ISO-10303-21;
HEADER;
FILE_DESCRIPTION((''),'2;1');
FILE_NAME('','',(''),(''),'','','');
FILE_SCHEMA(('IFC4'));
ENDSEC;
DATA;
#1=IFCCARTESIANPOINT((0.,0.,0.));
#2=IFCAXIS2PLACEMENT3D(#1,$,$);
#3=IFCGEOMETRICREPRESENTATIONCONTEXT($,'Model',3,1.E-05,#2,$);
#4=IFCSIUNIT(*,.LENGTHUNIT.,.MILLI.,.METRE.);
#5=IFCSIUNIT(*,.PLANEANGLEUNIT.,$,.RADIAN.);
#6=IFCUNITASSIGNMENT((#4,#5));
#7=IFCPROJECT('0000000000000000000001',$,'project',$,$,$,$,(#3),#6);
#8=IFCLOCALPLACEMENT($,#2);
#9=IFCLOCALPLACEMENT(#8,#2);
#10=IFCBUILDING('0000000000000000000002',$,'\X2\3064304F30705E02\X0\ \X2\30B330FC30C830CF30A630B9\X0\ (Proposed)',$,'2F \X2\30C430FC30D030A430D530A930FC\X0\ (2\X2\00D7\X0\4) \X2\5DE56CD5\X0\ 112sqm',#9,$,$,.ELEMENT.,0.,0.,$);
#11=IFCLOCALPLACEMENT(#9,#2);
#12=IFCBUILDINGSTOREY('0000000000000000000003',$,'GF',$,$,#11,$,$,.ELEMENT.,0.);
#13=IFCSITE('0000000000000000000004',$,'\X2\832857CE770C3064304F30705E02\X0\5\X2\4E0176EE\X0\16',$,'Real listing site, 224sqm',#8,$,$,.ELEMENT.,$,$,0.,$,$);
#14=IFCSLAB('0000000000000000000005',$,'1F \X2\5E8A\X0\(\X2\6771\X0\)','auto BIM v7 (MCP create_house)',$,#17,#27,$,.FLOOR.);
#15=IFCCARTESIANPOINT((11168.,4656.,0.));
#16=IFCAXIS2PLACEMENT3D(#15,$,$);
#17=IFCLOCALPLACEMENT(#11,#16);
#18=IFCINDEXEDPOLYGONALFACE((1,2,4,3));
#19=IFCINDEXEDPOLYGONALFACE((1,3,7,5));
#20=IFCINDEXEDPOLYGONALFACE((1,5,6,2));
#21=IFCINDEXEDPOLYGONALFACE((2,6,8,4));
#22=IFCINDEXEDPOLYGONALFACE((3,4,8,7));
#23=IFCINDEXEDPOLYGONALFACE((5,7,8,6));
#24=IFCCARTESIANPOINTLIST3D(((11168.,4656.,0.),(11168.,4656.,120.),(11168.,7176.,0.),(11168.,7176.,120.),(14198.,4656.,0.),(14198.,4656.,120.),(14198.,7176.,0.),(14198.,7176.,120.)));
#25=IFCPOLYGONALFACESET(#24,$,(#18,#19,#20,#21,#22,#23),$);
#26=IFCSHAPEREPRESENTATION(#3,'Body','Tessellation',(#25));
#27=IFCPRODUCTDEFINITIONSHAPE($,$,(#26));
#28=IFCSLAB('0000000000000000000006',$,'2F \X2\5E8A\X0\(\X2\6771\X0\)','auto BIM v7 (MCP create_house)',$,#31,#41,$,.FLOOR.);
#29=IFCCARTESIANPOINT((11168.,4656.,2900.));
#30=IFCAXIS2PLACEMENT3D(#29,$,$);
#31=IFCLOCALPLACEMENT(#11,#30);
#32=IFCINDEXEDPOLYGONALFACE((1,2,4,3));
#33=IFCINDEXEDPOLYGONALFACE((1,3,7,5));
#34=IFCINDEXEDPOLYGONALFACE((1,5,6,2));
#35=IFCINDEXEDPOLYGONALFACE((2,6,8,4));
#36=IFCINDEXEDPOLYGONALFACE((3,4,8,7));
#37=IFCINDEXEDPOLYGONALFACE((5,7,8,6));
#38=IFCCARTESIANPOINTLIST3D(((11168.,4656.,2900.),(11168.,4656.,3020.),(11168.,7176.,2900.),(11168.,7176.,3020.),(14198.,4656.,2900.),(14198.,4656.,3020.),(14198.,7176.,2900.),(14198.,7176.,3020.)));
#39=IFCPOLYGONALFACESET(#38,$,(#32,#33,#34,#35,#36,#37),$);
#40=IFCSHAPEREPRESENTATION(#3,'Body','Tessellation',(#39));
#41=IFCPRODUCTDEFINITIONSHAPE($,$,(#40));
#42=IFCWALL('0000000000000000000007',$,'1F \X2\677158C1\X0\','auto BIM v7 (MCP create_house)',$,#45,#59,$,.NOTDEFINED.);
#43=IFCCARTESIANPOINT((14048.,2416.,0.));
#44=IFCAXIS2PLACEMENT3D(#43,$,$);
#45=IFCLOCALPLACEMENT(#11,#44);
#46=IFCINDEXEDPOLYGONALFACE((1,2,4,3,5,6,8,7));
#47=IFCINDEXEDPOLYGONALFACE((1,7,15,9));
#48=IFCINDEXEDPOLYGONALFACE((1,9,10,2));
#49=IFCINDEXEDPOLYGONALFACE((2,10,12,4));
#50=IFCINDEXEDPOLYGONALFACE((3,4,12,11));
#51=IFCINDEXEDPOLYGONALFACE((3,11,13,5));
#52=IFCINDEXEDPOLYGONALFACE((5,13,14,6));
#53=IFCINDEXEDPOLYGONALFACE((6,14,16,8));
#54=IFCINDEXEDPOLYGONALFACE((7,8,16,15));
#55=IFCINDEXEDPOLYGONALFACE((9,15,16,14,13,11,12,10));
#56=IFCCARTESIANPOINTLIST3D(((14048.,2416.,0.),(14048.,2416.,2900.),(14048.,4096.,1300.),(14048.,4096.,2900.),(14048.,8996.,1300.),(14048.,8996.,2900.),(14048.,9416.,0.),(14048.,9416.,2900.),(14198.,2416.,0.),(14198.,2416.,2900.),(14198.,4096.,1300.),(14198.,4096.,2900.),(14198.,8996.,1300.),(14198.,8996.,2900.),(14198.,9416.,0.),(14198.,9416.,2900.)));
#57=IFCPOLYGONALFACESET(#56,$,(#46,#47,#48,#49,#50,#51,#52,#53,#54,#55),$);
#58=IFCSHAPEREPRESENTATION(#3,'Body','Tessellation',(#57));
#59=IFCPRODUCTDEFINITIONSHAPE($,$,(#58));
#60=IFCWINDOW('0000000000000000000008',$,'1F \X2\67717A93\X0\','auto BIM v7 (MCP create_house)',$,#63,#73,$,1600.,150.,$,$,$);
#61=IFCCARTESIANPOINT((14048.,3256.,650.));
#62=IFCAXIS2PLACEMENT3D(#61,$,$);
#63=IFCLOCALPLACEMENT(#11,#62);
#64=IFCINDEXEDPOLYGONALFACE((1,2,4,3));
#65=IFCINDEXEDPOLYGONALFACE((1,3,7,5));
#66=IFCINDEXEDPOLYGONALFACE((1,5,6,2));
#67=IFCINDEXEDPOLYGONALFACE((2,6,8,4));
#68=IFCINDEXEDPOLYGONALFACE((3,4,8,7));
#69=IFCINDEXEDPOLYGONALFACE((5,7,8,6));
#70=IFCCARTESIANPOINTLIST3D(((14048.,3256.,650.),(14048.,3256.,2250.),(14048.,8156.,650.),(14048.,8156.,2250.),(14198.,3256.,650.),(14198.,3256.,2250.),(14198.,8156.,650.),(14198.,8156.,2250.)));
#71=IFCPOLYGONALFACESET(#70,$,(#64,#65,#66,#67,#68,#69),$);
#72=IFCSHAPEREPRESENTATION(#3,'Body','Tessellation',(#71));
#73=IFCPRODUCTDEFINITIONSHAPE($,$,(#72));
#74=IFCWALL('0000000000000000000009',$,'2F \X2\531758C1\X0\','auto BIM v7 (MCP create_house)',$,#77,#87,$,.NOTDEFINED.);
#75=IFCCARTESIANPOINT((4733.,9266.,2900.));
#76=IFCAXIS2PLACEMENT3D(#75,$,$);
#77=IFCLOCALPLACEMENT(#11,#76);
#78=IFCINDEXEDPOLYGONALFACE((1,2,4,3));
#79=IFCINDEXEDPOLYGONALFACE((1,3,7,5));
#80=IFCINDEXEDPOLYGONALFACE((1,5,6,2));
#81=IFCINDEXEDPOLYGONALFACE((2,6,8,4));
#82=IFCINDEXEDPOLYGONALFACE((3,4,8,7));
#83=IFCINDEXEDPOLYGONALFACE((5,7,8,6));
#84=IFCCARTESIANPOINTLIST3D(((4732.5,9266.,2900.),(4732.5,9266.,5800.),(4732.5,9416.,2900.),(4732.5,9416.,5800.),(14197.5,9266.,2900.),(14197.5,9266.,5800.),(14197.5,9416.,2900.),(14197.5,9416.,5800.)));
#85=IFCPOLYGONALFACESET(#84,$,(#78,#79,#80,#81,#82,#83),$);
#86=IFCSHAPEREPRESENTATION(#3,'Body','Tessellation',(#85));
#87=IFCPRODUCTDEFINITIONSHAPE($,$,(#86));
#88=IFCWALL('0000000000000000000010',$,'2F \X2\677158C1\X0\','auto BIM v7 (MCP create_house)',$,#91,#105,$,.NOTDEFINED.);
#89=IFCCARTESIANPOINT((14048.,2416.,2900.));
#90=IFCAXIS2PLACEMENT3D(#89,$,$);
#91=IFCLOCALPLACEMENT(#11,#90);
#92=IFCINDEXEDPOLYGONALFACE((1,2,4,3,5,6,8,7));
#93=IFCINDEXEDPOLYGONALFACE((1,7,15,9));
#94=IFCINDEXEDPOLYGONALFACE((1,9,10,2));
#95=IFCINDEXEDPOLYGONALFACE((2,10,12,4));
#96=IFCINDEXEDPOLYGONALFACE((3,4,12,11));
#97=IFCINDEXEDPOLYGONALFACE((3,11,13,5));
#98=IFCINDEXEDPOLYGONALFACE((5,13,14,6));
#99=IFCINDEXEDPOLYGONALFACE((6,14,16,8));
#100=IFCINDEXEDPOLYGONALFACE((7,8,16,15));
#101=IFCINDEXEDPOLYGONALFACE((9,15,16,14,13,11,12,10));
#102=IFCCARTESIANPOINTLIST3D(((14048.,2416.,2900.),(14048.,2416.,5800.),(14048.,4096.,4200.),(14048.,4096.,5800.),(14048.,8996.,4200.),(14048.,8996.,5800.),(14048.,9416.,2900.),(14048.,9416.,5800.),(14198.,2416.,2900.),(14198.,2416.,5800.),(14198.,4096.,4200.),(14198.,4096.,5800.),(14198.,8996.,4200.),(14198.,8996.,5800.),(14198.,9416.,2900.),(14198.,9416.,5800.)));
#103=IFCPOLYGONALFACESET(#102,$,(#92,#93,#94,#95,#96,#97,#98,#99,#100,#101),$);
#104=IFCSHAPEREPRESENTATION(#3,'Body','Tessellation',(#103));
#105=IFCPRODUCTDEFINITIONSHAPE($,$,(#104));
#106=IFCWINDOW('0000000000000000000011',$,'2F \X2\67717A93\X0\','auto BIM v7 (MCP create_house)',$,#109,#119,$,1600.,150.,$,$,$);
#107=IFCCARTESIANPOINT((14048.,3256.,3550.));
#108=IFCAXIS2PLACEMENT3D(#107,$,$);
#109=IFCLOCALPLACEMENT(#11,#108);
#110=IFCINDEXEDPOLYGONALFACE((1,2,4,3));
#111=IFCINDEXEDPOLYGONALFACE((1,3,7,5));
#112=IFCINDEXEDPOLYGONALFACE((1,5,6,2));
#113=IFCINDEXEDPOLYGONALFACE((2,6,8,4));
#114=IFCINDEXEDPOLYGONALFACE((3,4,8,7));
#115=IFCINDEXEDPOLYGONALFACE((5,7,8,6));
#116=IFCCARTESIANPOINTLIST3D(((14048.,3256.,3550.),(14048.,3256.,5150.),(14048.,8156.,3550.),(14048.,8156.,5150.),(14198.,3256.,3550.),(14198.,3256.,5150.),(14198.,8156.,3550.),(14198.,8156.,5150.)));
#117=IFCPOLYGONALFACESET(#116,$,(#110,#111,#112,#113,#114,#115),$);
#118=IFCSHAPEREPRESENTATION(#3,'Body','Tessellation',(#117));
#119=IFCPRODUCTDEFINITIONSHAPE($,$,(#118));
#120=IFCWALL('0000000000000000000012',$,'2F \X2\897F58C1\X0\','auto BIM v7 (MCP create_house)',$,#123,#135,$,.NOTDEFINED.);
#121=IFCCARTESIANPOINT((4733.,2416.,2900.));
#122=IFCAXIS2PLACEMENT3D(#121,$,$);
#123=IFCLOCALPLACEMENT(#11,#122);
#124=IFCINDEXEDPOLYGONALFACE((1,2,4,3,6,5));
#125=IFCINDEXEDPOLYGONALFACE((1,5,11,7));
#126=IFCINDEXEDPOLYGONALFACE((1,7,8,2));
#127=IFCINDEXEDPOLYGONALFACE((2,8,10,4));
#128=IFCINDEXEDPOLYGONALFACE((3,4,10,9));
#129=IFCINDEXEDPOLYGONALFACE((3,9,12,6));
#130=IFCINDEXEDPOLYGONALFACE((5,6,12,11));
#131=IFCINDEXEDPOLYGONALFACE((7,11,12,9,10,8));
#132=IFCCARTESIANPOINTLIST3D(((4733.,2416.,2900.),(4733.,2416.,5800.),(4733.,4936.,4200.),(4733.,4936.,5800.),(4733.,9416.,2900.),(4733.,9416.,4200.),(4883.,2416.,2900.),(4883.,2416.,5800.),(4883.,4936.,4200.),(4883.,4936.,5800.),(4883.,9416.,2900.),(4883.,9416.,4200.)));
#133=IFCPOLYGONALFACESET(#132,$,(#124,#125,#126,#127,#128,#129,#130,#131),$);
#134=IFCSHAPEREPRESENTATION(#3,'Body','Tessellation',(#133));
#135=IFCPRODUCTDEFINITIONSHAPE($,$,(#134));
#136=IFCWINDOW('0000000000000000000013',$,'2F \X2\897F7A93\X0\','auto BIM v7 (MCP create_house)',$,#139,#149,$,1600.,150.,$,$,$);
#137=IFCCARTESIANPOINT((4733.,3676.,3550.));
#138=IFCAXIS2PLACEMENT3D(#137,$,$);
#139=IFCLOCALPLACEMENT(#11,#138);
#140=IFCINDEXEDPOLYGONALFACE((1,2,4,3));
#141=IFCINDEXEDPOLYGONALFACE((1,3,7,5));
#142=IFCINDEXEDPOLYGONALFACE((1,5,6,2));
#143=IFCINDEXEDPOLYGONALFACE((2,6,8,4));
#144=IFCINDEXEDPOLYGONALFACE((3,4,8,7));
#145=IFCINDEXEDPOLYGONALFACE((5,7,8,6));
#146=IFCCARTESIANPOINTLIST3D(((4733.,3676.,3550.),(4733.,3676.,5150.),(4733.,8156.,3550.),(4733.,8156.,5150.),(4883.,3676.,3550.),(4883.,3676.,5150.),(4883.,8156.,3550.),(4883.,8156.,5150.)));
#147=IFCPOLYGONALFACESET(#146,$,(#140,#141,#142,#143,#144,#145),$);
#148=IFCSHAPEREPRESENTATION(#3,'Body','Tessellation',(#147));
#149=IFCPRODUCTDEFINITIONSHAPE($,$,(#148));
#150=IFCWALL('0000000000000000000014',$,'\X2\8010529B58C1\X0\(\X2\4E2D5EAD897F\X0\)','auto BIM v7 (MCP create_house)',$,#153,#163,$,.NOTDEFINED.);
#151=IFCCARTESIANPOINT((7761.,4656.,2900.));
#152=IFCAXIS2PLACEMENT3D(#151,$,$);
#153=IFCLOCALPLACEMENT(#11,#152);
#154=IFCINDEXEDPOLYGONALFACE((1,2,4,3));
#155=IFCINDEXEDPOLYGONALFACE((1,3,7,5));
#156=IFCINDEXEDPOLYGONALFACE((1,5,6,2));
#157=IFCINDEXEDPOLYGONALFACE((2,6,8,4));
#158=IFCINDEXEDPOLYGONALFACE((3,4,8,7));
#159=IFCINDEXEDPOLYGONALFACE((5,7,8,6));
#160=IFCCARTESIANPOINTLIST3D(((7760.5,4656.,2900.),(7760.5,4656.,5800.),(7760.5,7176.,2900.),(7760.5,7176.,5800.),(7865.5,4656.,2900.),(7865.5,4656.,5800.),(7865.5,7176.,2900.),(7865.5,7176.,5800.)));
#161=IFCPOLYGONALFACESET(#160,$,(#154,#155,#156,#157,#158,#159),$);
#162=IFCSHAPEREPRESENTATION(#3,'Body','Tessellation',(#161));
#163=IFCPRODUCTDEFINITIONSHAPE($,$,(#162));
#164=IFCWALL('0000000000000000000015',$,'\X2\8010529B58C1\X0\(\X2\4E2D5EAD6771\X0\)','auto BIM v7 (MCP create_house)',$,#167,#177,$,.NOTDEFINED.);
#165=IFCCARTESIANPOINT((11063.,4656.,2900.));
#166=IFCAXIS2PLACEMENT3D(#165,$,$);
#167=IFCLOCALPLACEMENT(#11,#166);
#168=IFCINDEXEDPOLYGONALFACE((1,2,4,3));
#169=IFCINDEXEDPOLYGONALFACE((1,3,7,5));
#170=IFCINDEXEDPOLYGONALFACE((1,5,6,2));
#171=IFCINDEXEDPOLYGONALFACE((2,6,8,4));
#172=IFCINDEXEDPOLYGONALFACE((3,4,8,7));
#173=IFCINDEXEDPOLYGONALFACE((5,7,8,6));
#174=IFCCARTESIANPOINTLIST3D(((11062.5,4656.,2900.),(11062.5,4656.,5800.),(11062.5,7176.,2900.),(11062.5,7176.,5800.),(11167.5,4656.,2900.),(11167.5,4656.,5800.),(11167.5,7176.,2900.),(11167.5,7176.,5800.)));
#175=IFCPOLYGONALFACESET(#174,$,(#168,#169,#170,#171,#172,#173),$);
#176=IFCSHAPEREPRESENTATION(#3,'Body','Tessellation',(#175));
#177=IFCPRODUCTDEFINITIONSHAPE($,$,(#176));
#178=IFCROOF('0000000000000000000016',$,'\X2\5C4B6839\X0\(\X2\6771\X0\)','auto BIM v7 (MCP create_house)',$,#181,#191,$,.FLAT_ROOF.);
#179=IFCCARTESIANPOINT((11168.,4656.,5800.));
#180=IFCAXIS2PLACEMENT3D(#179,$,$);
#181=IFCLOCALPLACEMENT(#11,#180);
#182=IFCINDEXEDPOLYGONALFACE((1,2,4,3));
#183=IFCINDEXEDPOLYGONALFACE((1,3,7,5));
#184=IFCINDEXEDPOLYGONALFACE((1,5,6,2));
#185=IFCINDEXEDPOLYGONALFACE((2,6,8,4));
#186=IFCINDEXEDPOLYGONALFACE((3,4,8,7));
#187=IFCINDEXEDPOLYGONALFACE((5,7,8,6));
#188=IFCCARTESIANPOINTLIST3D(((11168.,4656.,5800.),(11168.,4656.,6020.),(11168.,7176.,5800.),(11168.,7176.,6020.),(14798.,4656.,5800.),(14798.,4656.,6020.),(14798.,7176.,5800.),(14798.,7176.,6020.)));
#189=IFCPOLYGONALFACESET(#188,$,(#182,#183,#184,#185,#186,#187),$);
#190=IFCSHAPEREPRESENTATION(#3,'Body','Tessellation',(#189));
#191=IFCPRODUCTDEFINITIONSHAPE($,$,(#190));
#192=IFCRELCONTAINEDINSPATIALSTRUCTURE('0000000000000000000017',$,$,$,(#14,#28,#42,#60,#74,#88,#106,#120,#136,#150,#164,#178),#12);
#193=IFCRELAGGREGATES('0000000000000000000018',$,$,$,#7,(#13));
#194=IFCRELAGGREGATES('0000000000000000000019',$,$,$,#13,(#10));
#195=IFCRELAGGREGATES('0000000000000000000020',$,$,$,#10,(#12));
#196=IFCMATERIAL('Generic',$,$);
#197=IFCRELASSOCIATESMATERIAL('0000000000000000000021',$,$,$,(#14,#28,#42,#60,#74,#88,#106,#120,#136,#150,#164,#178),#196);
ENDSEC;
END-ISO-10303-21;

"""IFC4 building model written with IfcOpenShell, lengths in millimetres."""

from ifc_helpers import new_model, si_unit, frame, frame_2d, origin, place, context, project, spatial, rectangle, extrude, material, element, fill, save


model = new_model("IFC4")

# Units and contexts
model_context = context("Model", 3, precision=1e-05, world=origin())
ifc_project = project(units=[si_unit("LENGTHUNIT", "METRE", prefix="MILLI"), si_unit("PLANEANGLEUNIT", "RADIAN")], contexts=[model_context])

# Site, building, storey
site_placement = place(None, origin())
site = spatial("IfcSite", under=ifc_project, at=site_placement, Name="茨城県つくば市5丁目16", ObjectType="Real listing site, 224sqm", CompositionType="ELEMENT", RefElevation=0.0)
building_placement = place(site_placement, origin())
building = spatial("IfcBuilding", under=site, at=building_placement, Name="つくば市 コートハウス (Proposed)", ObjectType="2F ツーバイフォー (2×4) 工法 112sqm", CompositionType="ELEMENT", ElevationOfRefHeight=0.0, ElevationOfTerrain=0.0)
storey_placement = place(building_placement, origin())
storey = spatial("IfcBuildingStorey", under=building, at=storey_placement, Name="GF", CompositionType="ELEMENT", Elevation=0.0)

# Slabs
ifc_material = material(Name="Generic")
slab_1_placement = place(storey_placement, frame((11168.0, 4656.0, 0.0)))
element("IfcSlab", 1, at=slab_1_placement, inside=storey, material=ifc_material, Name="1F 床(東)", Description="auto BIM v7 (MCP create_house)", PredefinedType="FLOOR", context=model_context, shape_type="SweptSolid", body=[
    extrude(rectangle(XDim=3030.0, YDim=2520.0, at=frame_2d((1515.0, 1260.0))), frame((11168.0, 4656.0, 0.0)), (0.0, 0.0, 1.0), 120.0),
])
slab_2_placement = place(storey_placement, frame((11168.0, 4656.0, 2900.0)))
element("IfcSlab", 2, at=slab_2_placement, inside=storey, material=ifc_material, Name="2F 床(東)", Description="auto BIM v7 (MCP create_house)", PredefinedType="FLOOR", context=model_context, shape_type="SweptSolid", body=[
    extrude(rectangle(XDim=3030.0, YDim=2520.0, at=frame_2d((1515.0, 1260.0))), frame((11168.0, 4656.0, 2900.0)), (0.0, 0.0, 1.0), 120.0),
])

# Wall, opening, window
wall_1_placement = place(storey_placement, frame((14048.0, 2416.0, 0.0)))
wall_1 = element("IfcWall", 3, at=wall_1_placement, inside=storey, material=ifc_material, Name="1F 東壁", Description="auto BIM v7 (MCP create_house)", PredefinedType="NOTDEFINED", context=model_context, shape_type="SweptSolid", body=[
    extrude(rectangle(XDim=150.0, YDim=7000.0, at=frame_2d((75.0, 3500.0))), frame((14048.0, 2416.0, 0.0)), (0.0, 0.0, 1.0), 2900.0),
])
opening_1_placement = place(storey_placement, frame((14048.0, 3256.0, 650.0)))
opening_1 = element("IfcOpeningElement", 4, at=opening_1_placement, cuts=wall_1, PredefinedType="NOTDEFINED", context=model_context, shape_type="SweptSolid", body=[
    extrude(rectangle(XDim=150.0, YDim=4900.0, at=frame_2d((75.0, 2450.0))), frame((14048.0, 3256.0, 650.0)), (0.0, 0.0, 1.0), 1600.0),
])
window_1_placement = place(storey_placement, frame((14048.0, 3256.0, 650.0)))
window_1 = element("IfcWindow", 5, at=window_1_placement, inside=storey, material=ifc_material, Name="1F 東窓", Description="auto BIM v7 (MCP create_house)", OverallHeight=1600.0, OverallWidth=150.0, context=model_context, shape_type="SweptSolid", body=[
    extrude(rectangle(XDim=150.0, YDim=4900.0, at=frame_2d((75.0, 2450.0))), frame((14048.0, 3256.0, 650.0)), (0.0, 0.0, 1.0), 1600.0),
])
fill(opening_1, window_1)

# Wall
wall_2_placement = place(storey_placement, frame((4733.0, 9266.0, 2900.0)))
element("IfcWall", 6, at=wall_2_placement, inside=storey, material=ifc_material, Name="2F 北壁", Description="auto BIM v7 (MCP create_house)", PredefinedType="NOTDEFINED", context=model_context, shape_type="SweptSolid", body=[
    extrude(rectangle(XDim=9465.0, YDim=150.0, at=frame_2d((4732.0, 75.0))), frame((4733.0, 9266.0, 2900.0)), (0.0, 0.0, 1.0), 2900.0),
])

# Walls, openings, windows
wall_3_placement = place(storey_placement, frame((14048.0, 2416.0, 2900.0)))
wall_3 = element("IfcWall", 7, at=wall_3_placement, inside=storey, material=ifc_material, Name="2F 東壁", Description="auto BIM v7 (MCP create_house)", PredefinedType="NOTDEFINED", context=model_context, shape_type="SweptSolid", body=[
    extrude(rectangle(XDim=150.0, YDim=7000.0, at=frame_2d((75.0, 3500.0))), frame((14048.0, 2416.0, 2900.0)), (0.0, 0.0, 1.0), 2900.0),
])
opening_2_placement = place(storey_placement, frame((14048.0, 3256.0, 3550.0)))
opening_2 = element("IfcOpeningElement", 8, at=opening_2_placement, cuts=wall_3, PredefinedType="NOTDEFINED", context=model_context, shape_type="SweptSolid", body=[
    extrude(rectangle(XDim=150.0, YDim=4900.0, at=frame_2d((75.0, 2450.0))), frame((14048.0, 3256.0, 3550.0)), (0.0, 0.0, 1.0), 1600.0),
])
window_2_placement = place(storey_placement, frame((14048.0, 3256.0, 3550.0)))
window_2 = element("IfcWindow", 9, at=window_2_placement, inside=storey, material=ifc_material, Name="2F 東窓", Description="auto BIM v7 (MCP create_house)", OverallHeight=1600.0, OverallWidth=150.0, context=model_context, shape_type="SweptSolid", body=[
    extrude(rectangle(XDim=150.0, YDim=4900.0, at=frame_2d((75.0, 2450.0))), frame((14048.0, 3256.0, 3550.0)), (0.0, 0.0, 1.0), 1600.0),
])
fill(opening_2, window_2)
wall_4_placement = place(storey_placement, frame((4733.0, 2416.0, 2900.0)))
wall_4 = element("IfcWall", 10, at=wall_4_placement, inside=storey, material=ifc_material, Name="2F 西壁", Description="auto BIM v7 (MCP create_house)", PredefinedType="NOTDEFINED", context=model_context, shape_type="SweptSolid", body=[
    extrude(rectangle(XDim=150.0, YDim=7000.0, at=frame_2d((75.0, 3500.0))), frame((4733.0, 2416.0, 2900.0)), (0.0, 0.0, 1.0), 2900.0),
])
opening_3_placement = place(storey_placement, frame((4733.0, 3676.0, 3550.0)))
opening_3 = element("IfcOpeningElement", 11, at=opening_3_placement, cuts=wall_4, PredefinedType="NOTDEFINED", context=model_context, shape_type="SweptSolid", body=[
    extrude(rectangle(XDim=150.0, YDim=4480.0, at=frame_2d((75.0, 2240.0))), frame((4733.0, 3676.0, 3550.0)), (0.0, 0.0, 1.0), 1600.0),
])
window_3_placement = place(storey_placement, frame((4733.0, 3676.0, 3550.0)))
window_3 = element("IfcWindow", 12, at=window_3_placement, inside=storey, material=ifc_material, Name="2F 西窓", Description="auto BIM v7 (MCP create_house)", OverallHeight=1600.0, OverallWidth=150.0, context=model_context, shape_type="SweptSolid", body=[
    extrude(rectangle(XDim=150.0, YDim=4480.0, at=frame_2d((75.0, 2240.0))), frame((4733.0, 3676.0, 3550.0)), (0.0, 0.0, 1.0), 1600.0),
])
fill(opening_3, window_3)

# Walls
wall_5_placement = place(storey_placement, frame((7761.0, 4656.0, 2900.0)))
element("IfcWall", 13, at=wall_5_placement, inside=storey, material=ifc_material, Name="耐力壁(中庭西)", Description="auto BIM v7 (MCP create_house)", PredefinedType="NOTDEFINED", context=model_context, shape_type="SweptSolid", body=[
    extrude(rectangle(XDim=105.0, YDim=2520.0, at=frame_2d((52.0, 1260.0))), frame((7761.0, 4656.0, 2900.0)), (0.0, 0.0, 1.0), 2900.0),
])
wall_6_placement = place(storey_placement, frame((11063.0, 4656.0, 2900.0)))
element("IfcWall", 14, at=wall_6_placement, inside=storey, material=ifc_material, Name="耐力壁(中庭東)", Description="auto BIM v7 (MCP create_house)", PredefinedType="NOTDEFINED", context=model_context, shape_type="SweptSolid", body=[
    extrude(rectangle(XDim=105.0, YDim=2520.0, at=frame_2d((52.0, 1260.0))), frame((11063.0, 4656.0, 2900.0)), (0.0, 0.0, 1.0), 2900.0),
])

# Roof
for number, where, name in (
    (15, (11168.0, 4656.0, 5800.0), "屋根(東)"),
):
    element("IfcRoof", number, at=place(storey_placement, frame(where)), inside=storey, material=ifc_material, Name=name, Description="auto BIM v7 (MCP create_house)", PredefinedType="FLAT_ROOF", context=model_context, shape_type="SweptSolid", body=[
        extrude(rectangle(XDim=3630.0, YDim=2520.0, at=frame_2d((1815.0, 1260.0))), frame((11168.0, 4656.0, 5800.0)), (0.0, 0.0, 1.0), 220.0),
    ])

save(model, "model.ifc")
